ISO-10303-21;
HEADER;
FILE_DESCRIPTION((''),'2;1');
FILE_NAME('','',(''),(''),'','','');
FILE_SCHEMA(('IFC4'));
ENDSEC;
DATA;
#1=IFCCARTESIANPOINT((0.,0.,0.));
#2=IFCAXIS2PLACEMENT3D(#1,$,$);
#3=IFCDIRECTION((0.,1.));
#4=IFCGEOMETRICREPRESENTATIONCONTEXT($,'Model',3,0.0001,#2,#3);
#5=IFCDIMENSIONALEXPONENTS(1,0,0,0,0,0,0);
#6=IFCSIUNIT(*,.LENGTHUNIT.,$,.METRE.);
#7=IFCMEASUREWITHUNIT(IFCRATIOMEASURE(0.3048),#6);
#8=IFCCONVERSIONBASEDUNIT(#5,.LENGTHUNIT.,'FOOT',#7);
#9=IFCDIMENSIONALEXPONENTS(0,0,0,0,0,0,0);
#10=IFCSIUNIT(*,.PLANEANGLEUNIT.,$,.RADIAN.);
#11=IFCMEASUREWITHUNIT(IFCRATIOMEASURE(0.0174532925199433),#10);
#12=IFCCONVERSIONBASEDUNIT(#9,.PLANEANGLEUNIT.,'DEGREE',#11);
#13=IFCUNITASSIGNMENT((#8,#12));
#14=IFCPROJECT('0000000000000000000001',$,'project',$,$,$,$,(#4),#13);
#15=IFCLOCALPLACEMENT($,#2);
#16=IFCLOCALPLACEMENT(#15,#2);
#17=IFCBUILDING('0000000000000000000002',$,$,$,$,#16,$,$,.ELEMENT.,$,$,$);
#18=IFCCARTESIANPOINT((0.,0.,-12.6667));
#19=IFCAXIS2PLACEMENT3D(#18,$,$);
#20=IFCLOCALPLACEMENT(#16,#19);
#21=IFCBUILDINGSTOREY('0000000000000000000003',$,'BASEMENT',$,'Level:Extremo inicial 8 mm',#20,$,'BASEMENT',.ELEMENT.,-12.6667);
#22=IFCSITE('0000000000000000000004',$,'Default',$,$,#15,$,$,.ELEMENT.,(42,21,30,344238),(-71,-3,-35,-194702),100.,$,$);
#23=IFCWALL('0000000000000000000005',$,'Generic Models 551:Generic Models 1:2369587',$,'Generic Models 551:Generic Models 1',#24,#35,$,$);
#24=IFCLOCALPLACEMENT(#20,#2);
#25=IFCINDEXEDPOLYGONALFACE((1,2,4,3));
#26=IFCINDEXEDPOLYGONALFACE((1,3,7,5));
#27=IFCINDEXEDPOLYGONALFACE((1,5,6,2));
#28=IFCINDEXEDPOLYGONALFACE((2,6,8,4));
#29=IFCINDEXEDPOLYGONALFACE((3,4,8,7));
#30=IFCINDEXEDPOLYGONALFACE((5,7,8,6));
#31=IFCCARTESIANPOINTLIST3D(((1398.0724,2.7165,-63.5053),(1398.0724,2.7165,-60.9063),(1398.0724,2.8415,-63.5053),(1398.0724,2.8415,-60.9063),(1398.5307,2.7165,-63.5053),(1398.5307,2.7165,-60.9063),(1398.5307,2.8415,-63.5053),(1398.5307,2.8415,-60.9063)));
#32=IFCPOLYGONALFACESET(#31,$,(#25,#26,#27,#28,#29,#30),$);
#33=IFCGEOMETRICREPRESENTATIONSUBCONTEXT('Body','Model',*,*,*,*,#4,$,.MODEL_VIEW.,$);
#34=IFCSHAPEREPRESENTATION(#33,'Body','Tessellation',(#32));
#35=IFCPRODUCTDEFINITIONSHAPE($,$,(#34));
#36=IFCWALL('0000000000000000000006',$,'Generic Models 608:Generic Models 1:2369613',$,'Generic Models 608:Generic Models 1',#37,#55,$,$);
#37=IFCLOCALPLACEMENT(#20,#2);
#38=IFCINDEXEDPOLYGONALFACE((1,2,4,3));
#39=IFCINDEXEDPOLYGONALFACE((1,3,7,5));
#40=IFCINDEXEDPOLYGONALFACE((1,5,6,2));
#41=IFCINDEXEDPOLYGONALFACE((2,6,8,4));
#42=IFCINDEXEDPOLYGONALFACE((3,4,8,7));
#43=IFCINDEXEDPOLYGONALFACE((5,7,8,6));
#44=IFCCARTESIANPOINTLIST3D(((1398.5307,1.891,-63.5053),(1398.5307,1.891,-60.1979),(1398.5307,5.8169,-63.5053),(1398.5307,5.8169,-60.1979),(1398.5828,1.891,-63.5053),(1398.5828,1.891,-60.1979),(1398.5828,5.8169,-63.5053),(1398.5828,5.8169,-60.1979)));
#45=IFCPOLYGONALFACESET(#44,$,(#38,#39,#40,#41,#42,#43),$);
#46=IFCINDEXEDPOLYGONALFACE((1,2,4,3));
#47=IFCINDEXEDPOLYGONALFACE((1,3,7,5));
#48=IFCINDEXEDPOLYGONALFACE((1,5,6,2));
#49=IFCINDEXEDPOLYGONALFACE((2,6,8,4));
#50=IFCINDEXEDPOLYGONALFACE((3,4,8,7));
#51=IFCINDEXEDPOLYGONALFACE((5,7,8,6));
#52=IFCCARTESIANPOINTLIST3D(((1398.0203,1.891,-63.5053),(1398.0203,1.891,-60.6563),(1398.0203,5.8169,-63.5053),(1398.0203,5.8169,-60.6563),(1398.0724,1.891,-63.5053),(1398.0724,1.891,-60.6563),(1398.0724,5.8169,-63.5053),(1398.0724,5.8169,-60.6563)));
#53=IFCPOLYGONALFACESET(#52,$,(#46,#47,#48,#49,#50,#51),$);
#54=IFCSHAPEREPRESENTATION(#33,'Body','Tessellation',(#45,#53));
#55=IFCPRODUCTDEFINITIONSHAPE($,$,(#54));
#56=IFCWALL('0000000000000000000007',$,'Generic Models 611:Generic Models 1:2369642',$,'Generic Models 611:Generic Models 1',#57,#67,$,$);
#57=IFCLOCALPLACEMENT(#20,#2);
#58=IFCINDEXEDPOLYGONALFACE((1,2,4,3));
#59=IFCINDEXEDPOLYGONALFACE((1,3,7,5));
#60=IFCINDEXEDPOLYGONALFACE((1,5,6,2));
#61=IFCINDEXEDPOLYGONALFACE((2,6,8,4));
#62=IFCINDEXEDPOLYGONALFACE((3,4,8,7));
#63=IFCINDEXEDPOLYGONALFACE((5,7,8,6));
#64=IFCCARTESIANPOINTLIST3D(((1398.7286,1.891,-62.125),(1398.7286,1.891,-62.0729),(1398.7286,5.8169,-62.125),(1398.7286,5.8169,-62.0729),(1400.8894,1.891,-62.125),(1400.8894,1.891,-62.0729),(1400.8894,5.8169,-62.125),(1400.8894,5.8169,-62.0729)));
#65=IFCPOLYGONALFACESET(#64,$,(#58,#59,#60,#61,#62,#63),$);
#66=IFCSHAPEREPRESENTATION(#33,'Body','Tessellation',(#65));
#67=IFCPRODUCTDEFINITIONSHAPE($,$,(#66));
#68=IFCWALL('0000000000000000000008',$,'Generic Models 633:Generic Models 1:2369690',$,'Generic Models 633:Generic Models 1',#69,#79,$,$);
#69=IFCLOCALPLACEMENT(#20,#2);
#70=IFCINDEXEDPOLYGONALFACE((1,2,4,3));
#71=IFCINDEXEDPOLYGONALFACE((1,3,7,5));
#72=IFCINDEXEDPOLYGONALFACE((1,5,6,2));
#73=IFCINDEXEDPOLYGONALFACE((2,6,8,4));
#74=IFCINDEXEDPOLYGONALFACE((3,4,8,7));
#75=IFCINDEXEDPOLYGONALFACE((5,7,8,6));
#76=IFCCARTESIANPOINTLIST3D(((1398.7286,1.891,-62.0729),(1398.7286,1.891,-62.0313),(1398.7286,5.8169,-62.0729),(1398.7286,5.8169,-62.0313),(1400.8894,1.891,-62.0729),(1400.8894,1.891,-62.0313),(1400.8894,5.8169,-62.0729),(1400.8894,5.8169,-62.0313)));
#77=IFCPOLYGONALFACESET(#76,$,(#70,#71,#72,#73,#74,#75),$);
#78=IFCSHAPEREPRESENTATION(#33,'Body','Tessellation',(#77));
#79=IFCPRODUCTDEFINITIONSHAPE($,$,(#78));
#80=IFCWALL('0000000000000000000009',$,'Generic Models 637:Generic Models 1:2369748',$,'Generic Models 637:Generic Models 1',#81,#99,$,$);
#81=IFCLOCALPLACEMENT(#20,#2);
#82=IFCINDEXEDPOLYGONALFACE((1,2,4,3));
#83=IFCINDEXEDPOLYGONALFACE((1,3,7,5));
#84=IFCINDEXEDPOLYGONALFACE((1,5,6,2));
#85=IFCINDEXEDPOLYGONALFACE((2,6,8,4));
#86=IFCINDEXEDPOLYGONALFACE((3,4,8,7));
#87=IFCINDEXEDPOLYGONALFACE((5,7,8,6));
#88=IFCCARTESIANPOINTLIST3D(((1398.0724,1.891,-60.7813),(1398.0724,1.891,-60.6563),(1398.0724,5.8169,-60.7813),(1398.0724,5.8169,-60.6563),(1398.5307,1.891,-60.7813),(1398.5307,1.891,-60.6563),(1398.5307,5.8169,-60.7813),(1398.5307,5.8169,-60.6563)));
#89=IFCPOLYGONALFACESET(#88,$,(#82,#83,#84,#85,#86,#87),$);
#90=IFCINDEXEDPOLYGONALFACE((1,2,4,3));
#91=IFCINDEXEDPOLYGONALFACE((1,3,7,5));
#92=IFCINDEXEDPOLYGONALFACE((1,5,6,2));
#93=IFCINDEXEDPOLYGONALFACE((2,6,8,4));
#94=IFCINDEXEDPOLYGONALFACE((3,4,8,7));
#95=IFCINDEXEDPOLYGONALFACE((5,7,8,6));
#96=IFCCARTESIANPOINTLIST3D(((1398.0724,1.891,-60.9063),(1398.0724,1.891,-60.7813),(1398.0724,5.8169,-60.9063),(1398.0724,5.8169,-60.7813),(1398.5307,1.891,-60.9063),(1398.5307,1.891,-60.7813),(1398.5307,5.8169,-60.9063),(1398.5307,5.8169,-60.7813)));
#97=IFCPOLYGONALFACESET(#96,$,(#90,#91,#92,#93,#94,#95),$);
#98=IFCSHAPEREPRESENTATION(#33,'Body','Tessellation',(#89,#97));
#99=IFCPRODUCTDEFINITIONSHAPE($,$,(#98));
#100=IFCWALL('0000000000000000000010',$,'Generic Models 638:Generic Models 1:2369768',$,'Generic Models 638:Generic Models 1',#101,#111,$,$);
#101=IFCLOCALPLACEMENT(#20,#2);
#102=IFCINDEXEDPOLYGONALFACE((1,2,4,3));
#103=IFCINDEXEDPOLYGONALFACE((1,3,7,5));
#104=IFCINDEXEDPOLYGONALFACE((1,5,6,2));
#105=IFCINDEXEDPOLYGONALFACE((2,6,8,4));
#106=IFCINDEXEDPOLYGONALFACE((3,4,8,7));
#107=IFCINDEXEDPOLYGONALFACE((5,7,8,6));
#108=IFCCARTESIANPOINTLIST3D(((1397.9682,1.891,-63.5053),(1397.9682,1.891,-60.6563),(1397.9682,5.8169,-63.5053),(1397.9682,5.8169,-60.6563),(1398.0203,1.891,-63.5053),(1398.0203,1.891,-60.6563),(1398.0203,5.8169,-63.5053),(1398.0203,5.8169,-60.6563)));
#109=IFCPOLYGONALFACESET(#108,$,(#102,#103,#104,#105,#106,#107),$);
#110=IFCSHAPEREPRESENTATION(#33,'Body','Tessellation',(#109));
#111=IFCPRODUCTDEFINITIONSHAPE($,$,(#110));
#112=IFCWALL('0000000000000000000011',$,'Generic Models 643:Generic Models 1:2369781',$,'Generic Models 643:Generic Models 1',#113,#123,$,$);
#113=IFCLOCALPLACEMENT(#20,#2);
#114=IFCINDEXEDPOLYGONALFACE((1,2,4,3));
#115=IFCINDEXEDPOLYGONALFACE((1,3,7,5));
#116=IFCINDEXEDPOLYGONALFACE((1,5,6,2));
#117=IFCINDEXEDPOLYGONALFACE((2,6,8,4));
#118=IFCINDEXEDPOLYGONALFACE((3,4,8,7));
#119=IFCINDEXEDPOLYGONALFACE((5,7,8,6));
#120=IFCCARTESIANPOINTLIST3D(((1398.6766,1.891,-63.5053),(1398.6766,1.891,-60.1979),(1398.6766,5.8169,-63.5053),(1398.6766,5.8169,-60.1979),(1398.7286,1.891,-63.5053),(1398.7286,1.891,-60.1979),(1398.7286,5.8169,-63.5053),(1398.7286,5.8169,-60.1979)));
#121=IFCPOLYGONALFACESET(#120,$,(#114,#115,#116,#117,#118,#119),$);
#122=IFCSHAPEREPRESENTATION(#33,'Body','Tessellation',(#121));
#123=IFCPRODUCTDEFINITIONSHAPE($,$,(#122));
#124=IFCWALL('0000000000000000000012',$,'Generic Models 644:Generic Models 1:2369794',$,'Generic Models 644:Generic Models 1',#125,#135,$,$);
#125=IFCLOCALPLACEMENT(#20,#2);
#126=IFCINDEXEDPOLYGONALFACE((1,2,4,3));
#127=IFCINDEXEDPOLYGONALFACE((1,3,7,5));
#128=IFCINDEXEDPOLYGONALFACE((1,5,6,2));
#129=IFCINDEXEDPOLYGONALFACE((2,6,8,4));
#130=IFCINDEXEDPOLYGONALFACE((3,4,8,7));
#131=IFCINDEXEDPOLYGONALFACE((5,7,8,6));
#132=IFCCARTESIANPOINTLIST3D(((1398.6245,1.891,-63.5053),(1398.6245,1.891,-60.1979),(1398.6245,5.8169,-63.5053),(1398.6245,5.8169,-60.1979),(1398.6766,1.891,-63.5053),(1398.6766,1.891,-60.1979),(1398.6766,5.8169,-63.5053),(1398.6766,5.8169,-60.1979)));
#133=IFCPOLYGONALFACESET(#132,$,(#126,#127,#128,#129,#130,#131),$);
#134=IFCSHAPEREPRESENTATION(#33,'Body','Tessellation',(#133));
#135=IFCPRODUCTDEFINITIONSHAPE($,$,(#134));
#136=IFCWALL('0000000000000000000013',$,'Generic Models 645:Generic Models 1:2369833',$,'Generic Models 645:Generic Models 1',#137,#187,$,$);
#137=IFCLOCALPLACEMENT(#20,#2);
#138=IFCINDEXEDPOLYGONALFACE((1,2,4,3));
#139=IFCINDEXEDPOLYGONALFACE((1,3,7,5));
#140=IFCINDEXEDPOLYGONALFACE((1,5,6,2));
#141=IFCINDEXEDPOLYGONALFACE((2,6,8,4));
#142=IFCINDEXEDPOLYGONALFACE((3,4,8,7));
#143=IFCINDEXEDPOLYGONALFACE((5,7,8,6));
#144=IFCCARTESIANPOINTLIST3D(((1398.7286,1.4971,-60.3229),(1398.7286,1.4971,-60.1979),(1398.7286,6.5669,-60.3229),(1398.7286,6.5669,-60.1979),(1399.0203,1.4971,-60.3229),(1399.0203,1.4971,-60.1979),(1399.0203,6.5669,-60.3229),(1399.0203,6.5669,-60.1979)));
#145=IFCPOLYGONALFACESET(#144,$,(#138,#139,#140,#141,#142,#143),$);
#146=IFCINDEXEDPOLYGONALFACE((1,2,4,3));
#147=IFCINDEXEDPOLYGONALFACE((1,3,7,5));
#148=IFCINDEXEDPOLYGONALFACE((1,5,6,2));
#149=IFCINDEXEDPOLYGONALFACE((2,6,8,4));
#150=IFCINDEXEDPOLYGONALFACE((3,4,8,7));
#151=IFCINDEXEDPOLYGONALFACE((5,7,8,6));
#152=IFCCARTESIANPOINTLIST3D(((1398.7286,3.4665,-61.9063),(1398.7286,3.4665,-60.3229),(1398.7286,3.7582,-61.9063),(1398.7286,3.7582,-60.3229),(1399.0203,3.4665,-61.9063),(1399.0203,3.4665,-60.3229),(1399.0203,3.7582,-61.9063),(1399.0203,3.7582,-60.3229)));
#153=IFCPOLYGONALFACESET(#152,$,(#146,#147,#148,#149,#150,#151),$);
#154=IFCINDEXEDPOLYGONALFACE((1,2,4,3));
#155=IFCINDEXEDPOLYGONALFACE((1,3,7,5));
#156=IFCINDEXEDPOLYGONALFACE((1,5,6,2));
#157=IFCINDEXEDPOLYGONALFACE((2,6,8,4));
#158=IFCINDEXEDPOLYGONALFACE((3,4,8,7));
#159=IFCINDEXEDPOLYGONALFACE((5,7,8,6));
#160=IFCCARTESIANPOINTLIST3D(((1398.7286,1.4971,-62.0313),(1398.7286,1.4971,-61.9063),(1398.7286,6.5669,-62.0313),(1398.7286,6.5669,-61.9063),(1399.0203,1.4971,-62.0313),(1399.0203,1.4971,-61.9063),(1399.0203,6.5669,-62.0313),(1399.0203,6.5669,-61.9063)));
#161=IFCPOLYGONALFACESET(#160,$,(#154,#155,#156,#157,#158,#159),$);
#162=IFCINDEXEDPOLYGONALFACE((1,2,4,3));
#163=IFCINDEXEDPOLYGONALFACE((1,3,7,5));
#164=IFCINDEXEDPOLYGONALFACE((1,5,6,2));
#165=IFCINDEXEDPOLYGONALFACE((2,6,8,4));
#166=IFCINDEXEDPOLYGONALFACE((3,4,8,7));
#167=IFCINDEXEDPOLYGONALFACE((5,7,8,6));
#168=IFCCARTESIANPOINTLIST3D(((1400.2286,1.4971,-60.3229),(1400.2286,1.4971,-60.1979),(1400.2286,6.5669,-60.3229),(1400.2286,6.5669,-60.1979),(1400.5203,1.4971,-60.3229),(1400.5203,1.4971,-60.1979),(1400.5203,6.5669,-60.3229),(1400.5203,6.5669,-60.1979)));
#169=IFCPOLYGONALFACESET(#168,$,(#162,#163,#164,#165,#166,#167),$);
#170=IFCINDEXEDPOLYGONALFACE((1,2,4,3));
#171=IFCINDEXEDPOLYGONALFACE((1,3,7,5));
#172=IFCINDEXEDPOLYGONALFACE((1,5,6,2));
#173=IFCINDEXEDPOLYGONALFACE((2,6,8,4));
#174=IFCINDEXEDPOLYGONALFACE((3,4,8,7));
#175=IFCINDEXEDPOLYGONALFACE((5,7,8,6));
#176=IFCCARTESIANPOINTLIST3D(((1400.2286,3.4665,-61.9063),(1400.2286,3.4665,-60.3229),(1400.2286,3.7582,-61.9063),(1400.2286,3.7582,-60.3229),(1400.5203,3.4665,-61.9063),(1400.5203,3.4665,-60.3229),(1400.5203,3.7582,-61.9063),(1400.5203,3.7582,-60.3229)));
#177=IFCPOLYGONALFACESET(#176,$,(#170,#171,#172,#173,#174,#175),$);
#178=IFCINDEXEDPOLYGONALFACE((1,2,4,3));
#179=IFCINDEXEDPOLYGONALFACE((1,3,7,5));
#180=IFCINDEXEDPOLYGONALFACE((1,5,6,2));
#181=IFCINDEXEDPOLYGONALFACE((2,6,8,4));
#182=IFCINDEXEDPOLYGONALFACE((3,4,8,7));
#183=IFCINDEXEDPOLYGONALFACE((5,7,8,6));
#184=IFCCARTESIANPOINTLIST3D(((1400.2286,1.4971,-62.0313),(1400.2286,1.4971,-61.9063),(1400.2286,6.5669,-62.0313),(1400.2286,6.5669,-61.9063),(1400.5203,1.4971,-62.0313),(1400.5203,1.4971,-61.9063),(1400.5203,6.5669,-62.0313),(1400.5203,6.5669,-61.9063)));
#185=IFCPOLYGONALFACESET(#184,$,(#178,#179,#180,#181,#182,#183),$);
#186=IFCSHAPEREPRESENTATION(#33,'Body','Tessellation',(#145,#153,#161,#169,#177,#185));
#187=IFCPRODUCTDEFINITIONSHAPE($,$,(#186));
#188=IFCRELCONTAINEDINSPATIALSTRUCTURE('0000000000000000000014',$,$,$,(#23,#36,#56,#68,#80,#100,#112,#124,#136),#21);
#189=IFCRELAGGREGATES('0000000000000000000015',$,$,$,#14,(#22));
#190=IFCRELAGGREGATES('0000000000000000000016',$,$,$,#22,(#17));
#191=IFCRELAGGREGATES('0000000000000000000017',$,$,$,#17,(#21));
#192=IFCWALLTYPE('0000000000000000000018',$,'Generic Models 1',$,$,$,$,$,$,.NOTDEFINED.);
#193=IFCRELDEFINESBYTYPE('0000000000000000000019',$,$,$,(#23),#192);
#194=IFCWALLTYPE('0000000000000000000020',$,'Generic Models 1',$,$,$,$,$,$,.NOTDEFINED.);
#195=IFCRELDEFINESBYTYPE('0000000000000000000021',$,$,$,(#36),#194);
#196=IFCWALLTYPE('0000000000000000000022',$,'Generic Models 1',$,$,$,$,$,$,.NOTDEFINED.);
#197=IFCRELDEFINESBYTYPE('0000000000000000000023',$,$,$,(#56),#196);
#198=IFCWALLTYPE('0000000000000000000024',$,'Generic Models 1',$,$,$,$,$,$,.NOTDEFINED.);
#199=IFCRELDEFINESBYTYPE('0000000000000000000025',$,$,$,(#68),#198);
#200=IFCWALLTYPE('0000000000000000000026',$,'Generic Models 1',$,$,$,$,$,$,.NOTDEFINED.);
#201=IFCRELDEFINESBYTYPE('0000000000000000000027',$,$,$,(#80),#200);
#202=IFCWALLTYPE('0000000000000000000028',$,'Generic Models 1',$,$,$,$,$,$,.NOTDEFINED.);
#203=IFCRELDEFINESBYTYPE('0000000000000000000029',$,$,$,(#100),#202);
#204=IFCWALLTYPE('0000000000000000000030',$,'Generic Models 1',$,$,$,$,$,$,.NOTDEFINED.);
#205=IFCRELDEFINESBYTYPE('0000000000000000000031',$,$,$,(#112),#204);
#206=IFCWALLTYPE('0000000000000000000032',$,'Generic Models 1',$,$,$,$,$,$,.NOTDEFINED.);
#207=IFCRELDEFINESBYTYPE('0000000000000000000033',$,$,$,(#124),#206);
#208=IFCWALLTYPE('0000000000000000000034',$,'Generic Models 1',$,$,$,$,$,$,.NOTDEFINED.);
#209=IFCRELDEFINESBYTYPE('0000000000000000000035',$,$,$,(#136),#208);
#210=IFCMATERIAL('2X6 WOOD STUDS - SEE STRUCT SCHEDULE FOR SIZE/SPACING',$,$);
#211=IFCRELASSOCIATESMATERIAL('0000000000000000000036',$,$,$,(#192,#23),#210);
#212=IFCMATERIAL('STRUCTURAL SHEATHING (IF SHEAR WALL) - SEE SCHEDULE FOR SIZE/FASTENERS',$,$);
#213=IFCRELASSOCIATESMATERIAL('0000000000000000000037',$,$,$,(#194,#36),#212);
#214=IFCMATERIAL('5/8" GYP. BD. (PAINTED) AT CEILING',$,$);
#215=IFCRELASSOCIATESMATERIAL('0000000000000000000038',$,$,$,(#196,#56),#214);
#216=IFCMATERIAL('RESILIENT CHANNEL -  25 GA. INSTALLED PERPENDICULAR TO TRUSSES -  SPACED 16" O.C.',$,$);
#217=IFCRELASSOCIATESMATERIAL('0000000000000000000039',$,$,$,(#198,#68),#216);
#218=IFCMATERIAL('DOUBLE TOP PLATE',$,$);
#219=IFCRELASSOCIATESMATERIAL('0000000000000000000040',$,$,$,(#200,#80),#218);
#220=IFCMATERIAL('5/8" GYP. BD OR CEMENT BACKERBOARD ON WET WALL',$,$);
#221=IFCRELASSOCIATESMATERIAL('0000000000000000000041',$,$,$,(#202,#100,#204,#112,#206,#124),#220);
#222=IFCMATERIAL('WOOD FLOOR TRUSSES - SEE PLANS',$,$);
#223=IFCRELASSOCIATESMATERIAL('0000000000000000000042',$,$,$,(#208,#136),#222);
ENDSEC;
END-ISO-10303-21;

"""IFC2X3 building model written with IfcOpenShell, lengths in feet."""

from ifc_helpers import new_model, entity, si_unit, converted_unit, direction, frame, frame_2d, origin, place, context, subcontext, project, spatial, rectangle, extrude, material, type_object, element, save


model = new_model("IFC2X3")

# Units and contexts
model_context = context("Model", 3, precision=0.0001, world=origin(), true_north=direction((0.0, 1.0)))
body_context = subcontext(model_context, "Body", "Model", "MODEL_VIEW")
ifc_project = project(units=[converted_unit("LENGTHUNIT", "FOOT", entity("IfcRatioMeasure", 0.3048), si_unit("LENGTHUNIT", "METRE"), dimensions=[1, 0, 0, 0, 0, 0, 0]), converted_unit("PLANEANGLEUNIT", "DEGREE", entity("IfcRatioMeasure", 0.0174532925199433), si_unit("PLANEANGLEUNIT", "RADIAN"), dimensions=[0, 0, 0, 0, 0, 0, 0])], contexts=[model_context])

# Site, building, storey
site_placement = place(None, origin())
site = spatial("IfcSite", under=ifc_project, at=site_placement, Name="Default", CompositionType="ELEMENT", RefLatitude=(42, 21, 30, 344238), RefLongitude=(-71, -3, -35, -194702), RefElevation=100.0)
building_placement = place(site_placement, origin())
building = spatial("IfcBuilding", under=site, at=building_placement, CompositionType="ELEMENT")
storey_placement = place(building_placement, frame((0.0, 0.0, -12.6667)))
storey = spatial("IfcBuildingStorey", under=building, at=storey_placement, Name="BASEMENT", ObjectType="Level:Extremo inicial 8 mm", LongName="BASEMENT", CompositionType="ELEMENT", Elevation=-12.6667)

# Walls
ifc_material_1 = material(Name="2X6 WOOD STUDS - SEE STRUCT SCHEDULE FOR SIZE/SPACING")
wall_type_1 = type_object("IfcWallType", Name="Generic Models 1", PredefinedType="NOTDEFINED", material=ifc_material_1)
wall_1_placement = place(storey_placement, frame((1398.0724, 2.7165, -63.5053)))
element("IfcWall", 1, at=wall_1_placement, inside=storey, type_object=wall_type_1, material=ifc_material_1, Name="Generic Models 551:Generic Models 1:2369587", ObjectType="Generic Models 551:Generic Models 1", context=body_context, shape_type="SweptSolid", body=[
    extrude(rectangle(XDim=0.125, YDim=0.4583, at=frame_2d((0.0, 0.0), x_axis=(1.0, 0.0))), frame((0.2292, 0.0625, 0.0), z_axis=(0.0, 0.0, 1.0), x_axis=(0.0, 1.0, 0.0)), (0.0, 0.0, 1.0), 2.599),
])
ifc_material_2 = material(Name="STRUCTURAL SHEATHING (IF SHEAR WALL) - SEE SCHEDULE FOR SIZE/FASTENERS")
wall_type_2 = type_object("IfcWallType", Name="Generic Models 1", PredefinedType="NOTDEFINED", material=ifc_material_2)
wall_2_placement = place(storey_placement, frame((1398.0203, 1.891, -63.5053), z_axis=(0.0, 0.0, 1.0), x_axis=(0.0, 1.0, 0.0)))
element("IfcWall", 2, at=wall_2_placement, inside=storey, type_object=wall_type_2, material=ifc_material_2, Name="Generic Models 608:Generic Models 1:2369613", ObjectType="Generic Models 608:Generic Models 1", context=body_context, shape_type="SweptSolid", body=[
    extrude(rectangle(XDim=3.9258, YDim=0.0521, at=frame_2d((0.0, 0.0), x_axis=(1.0, 0.0))), frame((1.9629, -0.5365, 0.0)), (0.0, 0.0, 1.0), 3.3074),
    extrude(rectangle(XDim=3.9258, YDim=0.0521, at=frame_2d((0.0, 0.0), x_axis=(1.0, 0.0))), frame((1.9629, -0.026, 0.0)), (0.0, 0.0, 1.0), 2.849),
])
ifc_material_3 = material(Name="5/8\" GYP. BD. (PAINTED) AT CEILING")
wall_type_3 = type_object("IfcWallType", Name="Generic Models 1", PredefinedType="NOTDEFINED", material=ifc_material_3)
wall_3_placement = place(storey_placement, frame((1398.7286, 1.891, -62.125), z_axis=(0.0, 0.0, 1.0), x_axis=(0.0, 1.0, 0.0)))
element("IfcWall", 3, at=wall_3_placement, inside=storey, type_object=wall_type_3, material=ifc_material_3, Name="Generic Models 611:Generic Models 1:2369642", ObjectType="Generic Models 611:Generic Models 1", context=body_context, shape_type="SweptSolid", body=[
    extrude(rectangle(XDim=3.9258, YDim=2.1608, at=frame_2d((0.0, 0.0), x_axis=(1.0, 0.0))), frame((1.9629, -1.0804, 0.0)), (0.0, 0.0, 1.0), 0.0521),
])
ifc_material_4 = material(Name="RESILIENT CHANNEL -  25 GA. INSTALLED PERPENDICULAR TO TRUSSES -  SPACED 16\" O.C.")
wall_type_4 = type_object("IfcWallType", Name="Generic Models 1", PredefinedType="NOTDEFINED", material=ifc_material_4)
wall_4_placement = place(storey_placement, frame((1398.7286, 1.891, -62.0729), z_axis=(0.0, 0.0, 1.0), x_axis=(0.0, 1.0, 0.0)))
element("IfcWall", 4, at=wall_4_placement, inside=storey, type_object=wall_type_4, material=ifc_material_4, Name="Generic Models 633:Generic Models 1:2369690", ObjectType="Generic Models 633:Generic Models 1", context=body_context, shape_type="SweptSolid", body=[
    extrude(rectangle(XDim=3.9258, YDim=2.1608, at=frame_2d((0.0, 0.0), x_axis=(1.0, 0.0))), frame((1.9629, -1.0804, 0.0)), (0.0, 0.0, 1.0), 0.0417),
])
ifc_material_5 = material(Name="DOUBLE TOP PLATE")
wall_type_5 = type_object("IfcWallType", Name="Generic Models 1", PredefinedType="NOTDEFINED", material=ifc_material_5)
wall_5_placement = place(storey_placement, frame((1398.0724, 1.891, -60.9063), z_axis=(0.0, 0.0, 1.0), x_axis=(0.0, 1.0, 0.0)))
element("IfcWall", 5, at=wall_5_placement, inside=storey, type_object=wall_type_5, material=ifc_material_5, Name="Generic Models 637:Generic Models 1:2369748", ObjectType="Generic Models 637:Generic Models 1", context=body_context, shape_type="SweptSolid", body=[
    extrude(rectangle(XDim=3.9258, YDim=0.4583, at=frame_2d((0.0, 0.0), x_axis=(1.0, 0.0))), frame((1.9629, -0.2292, 0.125)), (0.0, 0.0, 1.0), 0.125),
    extrude(rectangle(XDim=3.9258, YDim=0.4583, at=frame_2d((0.0, 0.0), x_axis=(1.0, 0.0))), frame((1.9629, -0.2292, 0.0)), (0.0, 0.0, 1.0), 0.125),
])
ifc_material_6 = material(Name="5/8\" GYP. BD OR CEMENT BACKERBOARD ON WET WALL")
wall_type_6 = type_object("IfcWallType", Name="Generic Models 1", PredefinedType="NOTDEFINED", material=ifc_material_6)
wall_6_placement = place(storey_placement, frame((1397.9682, 1.891, -63.5053), z_axis=(0.0, 0.0, 1.0), x_axis=(0.0, 1.0, 0.0)))
element("IfcWall", 6, at=wall_6_placement, inside=storey, type_object=wall_type_6, material=ifc_material_6, Name="Generic Models 638:Generic Models 1:2369768", ObjectType="Generic Models 638:Generic Models 1", context=body_context, shape_type="SweptSolid", body=[
    extrude(rectangle(XDim=3.9258, YDim=0.0521, at=frame_2d((0.0, 0.0), x_axis=(1.0, 0.0))), frame((1.9629, -0.026, 0.0)), (0.0, 0.0, 1.0), 2.849),
])
wall_type_7 = type_object("IfcWallType", Name="Generic Models 1", PredefinedType="NOTDEFINED", material=ifc_material_6)
wall_7_placement = place(storey_placement, frame((1398.6766, 1.891, -63.5053), z_axis=(0.0, 0.0, 1.0), x_axis=(0.0, 1.0, 0.0)))
element("IfcWall", 7, at=wall_7_placement, inside=storey, type_object=wall_type_7, material=ifc_material_6, Name="Generic Models 643:Generic Models 1:2369781", ObjectType="Generic Models 643:Generic Models 1", context=body_context, shape_type="SweptSolid", body=[
    extrude(rectangle(XDim=3.9258, YDim=0.0521, at=frame_2d((0.0, 0.0), x_axis=(1.0, 0.0))), frame((1.9629, -0.026, 0.0)), (0.0, 0.0, 1.0), 3.3074),
])
wall_type_8 = type_object("IfcWallType", Name="Generic Models 1", PredefinedType="NOTDEFINED", material=ifc_material_6)
wall_8_placement = place(storey_placement, frame((1398.6245, 1.891, -63.5053), z_axis=(0.0, 0.0, 1.0), x_axis=(0.0, 1.0, 0.0)))
element("IfcWall", 8, at=wall_8_placement, inside=storey, type_object=wall_type_8, material=ifc_material_6, Name="Generic Models 644:Generic Models 1:2369794", ObjectType="Generic Models 644:Generic Models 1", context=body_context, shape_type="SweptSolid", body=[
    extrude(rectangle(XDim=3.9258, YDim=0.0521, at=frame_2d((0.0, 0.0), x_axis=(1.0, 0.0))), frame((1.9629, -0.026, 0.0)), (0.0, 0.0, 1.0), 3.3074),
])
ifc_material_7 = material(Name="WOOD FLOOR TRUSSES - SEE PLANS")
wall_type_9 = type_object("IfcWallType", Name="Generic Models 1", PredefinedType="NOTDEFINED", material=ifc_material_7)
wall_9_placement = place(storey_placement, frame((1398.7286, 1.4971, -62.0313), z_axis=(0.0, 0.0, 1.0), x_axis=(0.0, 1.0, 0.0)))
element("IfcWall", 9, at=wall_9_placement, inside=storey, type_object=wall_type_9, material=ifc_material_7, Name="Generic Models 645:Generic Models 1:2369833", ObjectType="Generic Models 645:Generic Models 1", context=body_context, shape_type="SweptSolid", body=[
    extrude(rectangle(XDim=5.0697, YDim=0.2917, at=frame_2d((0.0, 0.0), x_axis=(1.0, 0.0))), frame((2.5349, -0.1458, 1.7083)), (0.0, 0.0, 1.0), 0.125),
    extrude(rectangle(XDim=0.2917, YDim=0.2917, at=frame_2d((0.0, 0.0), x_axis=(1.0, 0.0))), frame((2.1152, -0.1458, 0.125)), (0.0, 0.0, 1.0), 1.5833),
    extrude(rectangle(XDim=5.0697, YDim=0.2917, at=frame_2d((0.0, 0.0), x_axis=(1.0, 0.0))), frame((2.5349, -0.1458, 0.0)), (0.0, 0.0, 1.0), 0.125),
    extrude(rectangle(XDim=5.0697, YDim=0.2917, at=frame_2d((0.0, 0.0), x_axis=(1.0, 0.0))), frame((2.5349, -1.6458, 1.7083)), (0.0, 0.0, 1.0), 0.125),
    extrude(rectangle(XDim=0.2917, YDim=0.2917, at=frame_2d((0.0, 0.0), x_axis=(1.0, 0.0))), frame((2.1152, -1.6458, 0.125)), (0.0, 0.0, 1.0), 1.5833),
    extrude(rectangle(XDim=5.0697, YDim=0.2917, at=frame_2d((0.0, 0.0), x_axis=(1.0, 0.0))), frame((2.5349, -1.6458, 0.0)), (0.0, 0.0, 1.0), 0.125),
])

save(model, "model.ifc")
